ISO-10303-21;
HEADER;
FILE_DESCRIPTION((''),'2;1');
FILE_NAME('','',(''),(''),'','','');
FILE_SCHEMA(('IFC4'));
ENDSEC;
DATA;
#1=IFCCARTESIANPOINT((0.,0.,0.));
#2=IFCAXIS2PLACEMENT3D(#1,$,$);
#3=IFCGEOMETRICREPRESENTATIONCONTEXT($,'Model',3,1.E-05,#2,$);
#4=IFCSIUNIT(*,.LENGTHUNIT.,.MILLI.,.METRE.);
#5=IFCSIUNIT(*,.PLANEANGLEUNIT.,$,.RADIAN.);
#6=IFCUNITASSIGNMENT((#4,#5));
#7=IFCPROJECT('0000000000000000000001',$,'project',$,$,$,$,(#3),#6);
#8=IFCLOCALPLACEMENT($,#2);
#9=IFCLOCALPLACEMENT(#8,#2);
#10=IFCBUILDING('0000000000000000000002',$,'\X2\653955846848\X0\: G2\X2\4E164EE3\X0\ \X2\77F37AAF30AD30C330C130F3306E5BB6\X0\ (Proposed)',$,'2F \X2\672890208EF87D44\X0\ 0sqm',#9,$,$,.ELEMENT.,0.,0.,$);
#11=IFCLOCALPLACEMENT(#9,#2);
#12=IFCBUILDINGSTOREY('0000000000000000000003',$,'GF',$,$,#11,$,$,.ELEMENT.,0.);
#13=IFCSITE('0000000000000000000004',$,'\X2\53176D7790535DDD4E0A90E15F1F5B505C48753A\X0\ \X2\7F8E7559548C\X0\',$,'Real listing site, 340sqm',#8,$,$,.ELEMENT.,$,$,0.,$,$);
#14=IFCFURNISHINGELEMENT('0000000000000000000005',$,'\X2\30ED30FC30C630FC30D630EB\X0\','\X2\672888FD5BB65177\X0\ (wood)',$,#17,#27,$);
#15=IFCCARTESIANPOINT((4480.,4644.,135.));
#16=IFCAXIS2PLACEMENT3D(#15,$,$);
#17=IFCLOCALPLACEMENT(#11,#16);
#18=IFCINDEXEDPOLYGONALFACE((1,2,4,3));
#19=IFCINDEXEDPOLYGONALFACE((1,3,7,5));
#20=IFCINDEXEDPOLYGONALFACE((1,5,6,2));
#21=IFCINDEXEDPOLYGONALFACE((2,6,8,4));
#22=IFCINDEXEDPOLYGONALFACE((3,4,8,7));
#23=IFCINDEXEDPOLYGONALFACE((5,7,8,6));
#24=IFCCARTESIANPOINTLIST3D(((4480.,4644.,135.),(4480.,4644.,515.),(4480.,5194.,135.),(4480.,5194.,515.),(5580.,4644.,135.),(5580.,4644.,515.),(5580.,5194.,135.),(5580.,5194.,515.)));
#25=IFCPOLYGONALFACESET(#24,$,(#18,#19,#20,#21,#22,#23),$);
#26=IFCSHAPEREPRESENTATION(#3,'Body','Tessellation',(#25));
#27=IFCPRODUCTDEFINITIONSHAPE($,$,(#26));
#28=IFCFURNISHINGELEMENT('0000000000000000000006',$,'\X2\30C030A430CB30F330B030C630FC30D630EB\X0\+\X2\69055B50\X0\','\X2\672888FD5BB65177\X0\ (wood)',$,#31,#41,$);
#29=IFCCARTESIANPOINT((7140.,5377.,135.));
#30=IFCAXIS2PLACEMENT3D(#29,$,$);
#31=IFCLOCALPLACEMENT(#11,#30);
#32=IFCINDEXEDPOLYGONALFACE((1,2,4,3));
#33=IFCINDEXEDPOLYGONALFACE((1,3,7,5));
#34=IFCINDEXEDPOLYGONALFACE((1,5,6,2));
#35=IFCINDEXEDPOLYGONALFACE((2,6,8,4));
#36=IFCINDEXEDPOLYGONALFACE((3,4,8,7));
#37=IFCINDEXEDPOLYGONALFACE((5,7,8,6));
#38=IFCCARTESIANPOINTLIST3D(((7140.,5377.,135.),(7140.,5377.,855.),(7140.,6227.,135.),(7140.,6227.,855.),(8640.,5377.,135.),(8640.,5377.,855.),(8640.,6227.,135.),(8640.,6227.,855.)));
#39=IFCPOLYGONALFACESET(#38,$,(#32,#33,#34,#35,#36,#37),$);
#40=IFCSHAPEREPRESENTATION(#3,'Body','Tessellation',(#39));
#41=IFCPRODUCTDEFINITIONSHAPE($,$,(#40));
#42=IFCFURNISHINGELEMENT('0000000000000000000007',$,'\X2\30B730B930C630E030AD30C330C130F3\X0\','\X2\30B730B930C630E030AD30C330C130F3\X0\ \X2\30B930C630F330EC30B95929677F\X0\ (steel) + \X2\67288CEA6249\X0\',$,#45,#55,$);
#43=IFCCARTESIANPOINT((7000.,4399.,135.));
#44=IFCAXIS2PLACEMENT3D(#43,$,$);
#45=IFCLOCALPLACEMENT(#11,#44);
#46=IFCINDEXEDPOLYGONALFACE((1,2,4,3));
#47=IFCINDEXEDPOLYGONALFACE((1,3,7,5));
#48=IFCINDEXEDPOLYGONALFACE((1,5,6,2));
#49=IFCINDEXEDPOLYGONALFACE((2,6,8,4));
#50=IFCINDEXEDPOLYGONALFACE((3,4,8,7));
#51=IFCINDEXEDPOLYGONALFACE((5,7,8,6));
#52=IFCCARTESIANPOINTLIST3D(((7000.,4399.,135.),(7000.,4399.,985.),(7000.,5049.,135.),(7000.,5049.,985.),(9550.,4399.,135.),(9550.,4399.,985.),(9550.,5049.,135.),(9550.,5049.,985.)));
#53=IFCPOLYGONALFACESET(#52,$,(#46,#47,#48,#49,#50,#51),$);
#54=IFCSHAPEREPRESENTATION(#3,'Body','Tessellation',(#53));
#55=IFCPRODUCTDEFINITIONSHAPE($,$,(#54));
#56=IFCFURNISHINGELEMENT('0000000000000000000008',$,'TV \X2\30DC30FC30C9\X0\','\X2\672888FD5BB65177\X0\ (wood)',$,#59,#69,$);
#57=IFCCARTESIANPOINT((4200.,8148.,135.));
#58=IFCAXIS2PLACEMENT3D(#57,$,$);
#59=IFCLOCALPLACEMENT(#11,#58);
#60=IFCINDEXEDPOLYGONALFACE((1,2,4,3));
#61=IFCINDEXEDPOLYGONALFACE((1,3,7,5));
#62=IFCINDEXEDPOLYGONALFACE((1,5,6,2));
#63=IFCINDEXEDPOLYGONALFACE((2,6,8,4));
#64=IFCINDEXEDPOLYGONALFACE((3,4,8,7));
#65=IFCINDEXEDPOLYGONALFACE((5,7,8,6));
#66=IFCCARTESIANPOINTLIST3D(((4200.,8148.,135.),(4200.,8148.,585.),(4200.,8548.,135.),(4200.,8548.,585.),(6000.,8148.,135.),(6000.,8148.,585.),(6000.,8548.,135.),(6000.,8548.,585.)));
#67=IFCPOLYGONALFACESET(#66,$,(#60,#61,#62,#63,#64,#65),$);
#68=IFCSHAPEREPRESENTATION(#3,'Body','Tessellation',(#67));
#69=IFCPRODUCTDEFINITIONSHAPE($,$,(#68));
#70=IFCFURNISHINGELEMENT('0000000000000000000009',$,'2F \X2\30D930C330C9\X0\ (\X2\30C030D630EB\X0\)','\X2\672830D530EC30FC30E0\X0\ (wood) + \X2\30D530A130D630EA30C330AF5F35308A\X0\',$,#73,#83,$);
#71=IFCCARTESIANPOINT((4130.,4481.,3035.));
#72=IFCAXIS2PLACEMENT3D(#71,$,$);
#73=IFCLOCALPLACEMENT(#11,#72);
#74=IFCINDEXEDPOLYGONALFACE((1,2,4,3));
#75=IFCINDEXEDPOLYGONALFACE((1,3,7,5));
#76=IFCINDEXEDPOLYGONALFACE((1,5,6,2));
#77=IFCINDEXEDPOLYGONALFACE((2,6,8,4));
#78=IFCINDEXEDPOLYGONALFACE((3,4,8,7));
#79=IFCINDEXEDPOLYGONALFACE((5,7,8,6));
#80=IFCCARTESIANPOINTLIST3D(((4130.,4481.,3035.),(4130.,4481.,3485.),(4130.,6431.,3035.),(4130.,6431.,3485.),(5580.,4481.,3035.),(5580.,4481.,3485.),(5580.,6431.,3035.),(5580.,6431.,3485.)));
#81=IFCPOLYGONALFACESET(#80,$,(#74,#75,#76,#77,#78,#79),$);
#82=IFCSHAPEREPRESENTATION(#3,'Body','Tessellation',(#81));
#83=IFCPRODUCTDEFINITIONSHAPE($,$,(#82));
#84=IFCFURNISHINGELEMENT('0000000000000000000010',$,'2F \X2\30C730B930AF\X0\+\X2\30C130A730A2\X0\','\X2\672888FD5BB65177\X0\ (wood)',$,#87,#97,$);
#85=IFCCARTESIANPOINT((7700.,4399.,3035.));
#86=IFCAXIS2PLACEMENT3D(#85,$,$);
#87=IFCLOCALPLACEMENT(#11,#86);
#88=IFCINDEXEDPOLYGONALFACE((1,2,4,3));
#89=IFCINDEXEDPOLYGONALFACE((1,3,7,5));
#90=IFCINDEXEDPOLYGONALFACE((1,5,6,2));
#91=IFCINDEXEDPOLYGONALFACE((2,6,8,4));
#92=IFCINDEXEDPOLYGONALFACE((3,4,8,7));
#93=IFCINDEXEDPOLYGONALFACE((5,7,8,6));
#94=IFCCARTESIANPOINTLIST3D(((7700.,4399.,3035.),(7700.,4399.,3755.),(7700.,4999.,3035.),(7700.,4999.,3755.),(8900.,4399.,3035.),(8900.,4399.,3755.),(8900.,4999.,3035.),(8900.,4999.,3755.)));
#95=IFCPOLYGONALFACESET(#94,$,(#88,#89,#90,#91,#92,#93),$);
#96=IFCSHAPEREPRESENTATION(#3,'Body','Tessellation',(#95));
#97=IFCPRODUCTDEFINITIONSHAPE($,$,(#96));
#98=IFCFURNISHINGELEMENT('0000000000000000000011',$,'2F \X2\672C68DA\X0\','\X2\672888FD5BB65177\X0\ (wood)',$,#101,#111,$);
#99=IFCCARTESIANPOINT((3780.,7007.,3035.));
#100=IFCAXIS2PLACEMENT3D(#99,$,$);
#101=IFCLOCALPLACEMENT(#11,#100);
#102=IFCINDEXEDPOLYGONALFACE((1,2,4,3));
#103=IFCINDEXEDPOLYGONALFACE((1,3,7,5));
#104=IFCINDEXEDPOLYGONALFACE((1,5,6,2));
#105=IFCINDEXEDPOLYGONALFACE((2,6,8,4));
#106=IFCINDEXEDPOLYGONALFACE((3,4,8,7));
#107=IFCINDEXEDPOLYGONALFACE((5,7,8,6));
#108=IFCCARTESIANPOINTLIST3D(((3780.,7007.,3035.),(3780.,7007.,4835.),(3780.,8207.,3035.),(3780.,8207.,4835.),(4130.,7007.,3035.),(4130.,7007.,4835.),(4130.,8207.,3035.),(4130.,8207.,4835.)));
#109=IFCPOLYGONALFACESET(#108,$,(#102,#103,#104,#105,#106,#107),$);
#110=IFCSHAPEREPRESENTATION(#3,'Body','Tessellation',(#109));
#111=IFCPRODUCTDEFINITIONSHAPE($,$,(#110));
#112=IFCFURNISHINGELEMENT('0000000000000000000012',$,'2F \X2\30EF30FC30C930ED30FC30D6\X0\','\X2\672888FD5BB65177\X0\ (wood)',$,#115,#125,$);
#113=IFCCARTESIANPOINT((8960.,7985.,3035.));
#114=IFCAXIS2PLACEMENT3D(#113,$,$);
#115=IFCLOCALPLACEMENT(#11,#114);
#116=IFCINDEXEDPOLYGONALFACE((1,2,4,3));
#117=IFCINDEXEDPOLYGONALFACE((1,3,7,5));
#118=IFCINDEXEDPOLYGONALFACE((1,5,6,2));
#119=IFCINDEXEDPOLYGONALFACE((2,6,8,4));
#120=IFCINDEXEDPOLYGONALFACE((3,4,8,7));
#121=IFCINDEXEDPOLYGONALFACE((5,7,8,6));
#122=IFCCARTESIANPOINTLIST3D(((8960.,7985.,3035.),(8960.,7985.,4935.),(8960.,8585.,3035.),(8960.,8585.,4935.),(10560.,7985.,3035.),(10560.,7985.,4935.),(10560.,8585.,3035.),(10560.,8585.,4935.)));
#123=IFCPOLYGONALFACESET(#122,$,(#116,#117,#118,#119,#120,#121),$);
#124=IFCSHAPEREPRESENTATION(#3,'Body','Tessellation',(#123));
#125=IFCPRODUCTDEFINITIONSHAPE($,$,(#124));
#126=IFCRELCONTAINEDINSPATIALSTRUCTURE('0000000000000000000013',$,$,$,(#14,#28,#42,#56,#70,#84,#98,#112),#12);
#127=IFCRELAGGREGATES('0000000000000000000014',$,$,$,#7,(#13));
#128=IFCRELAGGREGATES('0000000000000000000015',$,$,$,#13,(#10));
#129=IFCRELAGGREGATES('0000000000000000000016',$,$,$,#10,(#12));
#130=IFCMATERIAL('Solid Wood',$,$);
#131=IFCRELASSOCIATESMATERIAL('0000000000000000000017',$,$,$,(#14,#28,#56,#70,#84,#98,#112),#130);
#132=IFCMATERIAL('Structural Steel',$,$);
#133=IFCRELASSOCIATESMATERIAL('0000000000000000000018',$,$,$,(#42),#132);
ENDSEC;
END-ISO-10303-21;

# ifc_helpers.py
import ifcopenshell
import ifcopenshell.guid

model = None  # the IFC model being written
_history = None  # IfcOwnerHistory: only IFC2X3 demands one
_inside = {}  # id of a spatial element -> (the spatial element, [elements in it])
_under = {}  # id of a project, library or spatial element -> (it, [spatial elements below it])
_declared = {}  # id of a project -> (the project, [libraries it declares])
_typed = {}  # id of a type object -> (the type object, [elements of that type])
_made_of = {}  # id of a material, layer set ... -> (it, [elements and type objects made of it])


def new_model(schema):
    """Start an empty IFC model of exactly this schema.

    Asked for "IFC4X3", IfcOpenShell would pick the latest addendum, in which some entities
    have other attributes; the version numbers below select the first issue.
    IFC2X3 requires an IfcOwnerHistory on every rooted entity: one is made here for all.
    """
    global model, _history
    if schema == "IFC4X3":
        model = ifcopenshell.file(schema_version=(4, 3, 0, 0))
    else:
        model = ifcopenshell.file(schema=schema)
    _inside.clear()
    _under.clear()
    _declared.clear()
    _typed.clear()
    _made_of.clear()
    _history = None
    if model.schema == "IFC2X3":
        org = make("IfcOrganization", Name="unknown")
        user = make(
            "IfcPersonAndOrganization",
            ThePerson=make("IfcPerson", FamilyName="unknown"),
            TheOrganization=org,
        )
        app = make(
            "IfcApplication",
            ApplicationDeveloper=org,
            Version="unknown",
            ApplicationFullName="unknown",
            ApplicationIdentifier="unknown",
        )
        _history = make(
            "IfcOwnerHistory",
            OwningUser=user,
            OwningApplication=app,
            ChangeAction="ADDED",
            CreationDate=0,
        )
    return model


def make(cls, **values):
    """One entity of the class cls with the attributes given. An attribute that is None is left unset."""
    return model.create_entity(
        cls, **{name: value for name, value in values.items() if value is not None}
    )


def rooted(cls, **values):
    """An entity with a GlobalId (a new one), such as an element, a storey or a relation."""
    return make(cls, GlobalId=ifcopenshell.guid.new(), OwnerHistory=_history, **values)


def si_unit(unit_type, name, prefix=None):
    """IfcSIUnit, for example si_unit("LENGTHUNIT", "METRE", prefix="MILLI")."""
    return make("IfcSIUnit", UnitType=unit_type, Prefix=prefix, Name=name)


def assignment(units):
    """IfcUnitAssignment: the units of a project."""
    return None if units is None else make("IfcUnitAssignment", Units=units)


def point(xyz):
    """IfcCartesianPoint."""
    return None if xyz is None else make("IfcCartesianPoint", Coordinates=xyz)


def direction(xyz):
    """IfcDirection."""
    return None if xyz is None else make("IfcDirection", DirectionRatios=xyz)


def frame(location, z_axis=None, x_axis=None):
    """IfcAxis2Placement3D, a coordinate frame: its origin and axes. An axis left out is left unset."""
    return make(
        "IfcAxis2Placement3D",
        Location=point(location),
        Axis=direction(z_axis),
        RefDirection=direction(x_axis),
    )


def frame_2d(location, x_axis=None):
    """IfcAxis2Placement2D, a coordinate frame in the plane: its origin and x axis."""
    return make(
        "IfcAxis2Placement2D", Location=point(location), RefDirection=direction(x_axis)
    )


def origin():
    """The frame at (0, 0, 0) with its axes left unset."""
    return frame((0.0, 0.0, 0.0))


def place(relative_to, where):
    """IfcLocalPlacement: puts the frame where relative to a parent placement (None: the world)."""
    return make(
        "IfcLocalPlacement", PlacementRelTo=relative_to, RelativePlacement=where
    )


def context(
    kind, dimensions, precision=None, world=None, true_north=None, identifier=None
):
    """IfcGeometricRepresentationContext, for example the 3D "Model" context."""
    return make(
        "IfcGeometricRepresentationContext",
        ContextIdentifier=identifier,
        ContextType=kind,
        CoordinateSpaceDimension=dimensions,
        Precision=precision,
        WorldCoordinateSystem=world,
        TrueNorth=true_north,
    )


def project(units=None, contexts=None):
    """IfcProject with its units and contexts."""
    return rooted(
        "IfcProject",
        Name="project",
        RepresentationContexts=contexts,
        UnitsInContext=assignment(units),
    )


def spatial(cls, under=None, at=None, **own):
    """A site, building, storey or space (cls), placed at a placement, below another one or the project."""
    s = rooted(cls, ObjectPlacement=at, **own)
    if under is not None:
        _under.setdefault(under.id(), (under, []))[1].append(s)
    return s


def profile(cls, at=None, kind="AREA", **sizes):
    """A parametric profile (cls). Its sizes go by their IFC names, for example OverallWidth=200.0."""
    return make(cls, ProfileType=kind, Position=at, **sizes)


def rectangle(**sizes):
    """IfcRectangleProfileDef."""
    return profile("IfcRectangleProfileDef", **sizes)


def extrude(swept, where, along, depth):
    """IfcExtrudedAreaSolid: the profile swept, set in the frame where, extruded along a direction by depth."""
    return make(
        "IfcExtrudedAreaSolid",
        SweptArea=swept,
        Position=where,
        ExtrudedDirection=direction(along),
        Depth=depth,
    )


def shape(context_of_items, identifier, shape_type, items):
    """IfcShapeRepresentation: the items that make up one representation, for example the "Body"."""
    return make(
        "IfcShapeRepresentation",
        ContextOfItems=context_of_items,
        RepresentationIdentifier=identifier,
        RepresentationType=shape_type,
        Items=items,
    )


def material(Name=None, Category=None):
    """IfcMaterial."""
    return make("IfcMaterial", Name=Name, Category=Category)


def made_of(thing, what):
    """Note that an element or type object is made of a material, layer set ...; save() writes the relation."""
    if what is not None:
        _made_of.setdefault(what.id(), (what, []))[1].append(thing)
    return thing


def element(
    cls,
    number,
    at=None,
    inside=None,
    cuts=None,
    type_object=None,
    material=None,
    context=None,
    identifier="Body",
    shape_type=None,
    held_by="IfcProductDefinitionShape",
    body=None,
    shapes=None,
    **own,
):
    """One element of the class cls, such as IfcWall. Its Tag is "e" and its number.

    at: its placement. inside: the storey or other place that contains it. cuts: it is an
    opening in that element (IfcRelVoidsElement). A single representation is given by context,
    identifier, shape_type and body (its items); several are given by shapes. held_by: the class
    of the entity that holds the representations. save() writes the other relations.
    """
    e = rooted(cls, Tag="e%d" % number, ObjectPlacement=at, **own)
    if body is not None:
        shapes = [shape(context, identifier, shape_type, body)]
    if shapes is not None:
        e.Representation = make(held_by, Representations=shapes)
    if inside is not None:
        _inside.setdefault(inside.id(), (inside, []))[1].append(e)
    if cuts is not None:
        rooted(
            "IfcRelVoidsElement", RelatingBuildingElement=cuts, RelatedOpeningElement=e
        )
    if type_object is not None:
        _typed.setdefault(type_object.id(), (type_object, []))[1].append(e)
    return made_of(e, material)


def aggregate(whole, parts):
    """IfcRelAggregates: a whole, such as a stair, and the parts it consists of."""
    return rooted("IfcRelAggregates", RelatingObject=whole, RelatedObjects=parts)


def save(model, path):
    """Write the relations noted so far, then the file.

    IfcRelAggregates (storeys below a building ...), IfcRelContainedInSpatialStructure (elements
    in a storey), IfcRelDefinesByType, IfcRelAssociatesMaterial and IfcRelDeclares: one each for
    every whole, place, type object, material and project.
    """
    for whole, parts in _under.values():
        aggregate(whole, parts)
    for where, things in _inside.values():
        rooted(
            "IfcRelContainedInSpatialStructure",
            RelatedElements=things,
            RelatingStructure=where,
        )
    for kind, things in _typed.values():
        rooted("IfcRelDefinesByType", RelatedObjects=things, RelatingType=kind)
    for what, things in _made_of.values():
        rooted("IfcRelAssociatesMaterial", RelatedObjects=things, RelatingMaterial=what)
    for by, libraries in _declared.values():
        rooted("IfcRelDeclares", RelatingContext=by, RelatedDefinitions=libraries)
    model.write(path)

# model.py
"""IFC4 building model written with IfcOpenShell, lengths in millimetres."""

from ifc_helpers import new_model, si_unit, frame, frame_2d, origin, place, context, project, spatial, rectangle, extrude, material, element, save


model = new_model("IFC4")

# Units and contexts
model_context = context("Model", 3, precision=1e-05, world=origin())
ifc_project = project(units=[si_unit("LENGTHUNIT", "METRE", prefix="MILLI"), si_unit("PLANEANGLEUNIT", "RADIAN")], contexts=[model_context])

# Site, building, storey
site_placement = place(None, origin())
site = spatial("IfcSite", under=ifc_project, at=site_placement, Name="北海道川上郡弟子屈町 美留和", ObjectType="Real listing site, 340sqm", CompositionType="ELEMENT", RefElevation=0.0)
building_placement = place(site_placement, origin())
building = spatial("IfcBuilding", under=site, at=building_placement, Name="改善案: G2世代 石窯キッチンの家 (Proposed)", ObjectType="2F 木造軸組 0sqm", CompositionType="ELEMENT", ElevationOfRefHeight=0.0, ElevationOfTerrain=0.0)
storey_placement = place(building_placement, origin())
storey = spatial("IfcBuildingStorey", under=building, at=storey_placement, Name="GF", CompositionType="ELEMENT", Elevation=0.0)

# Shared definitions
ifc_material_1 = material(Name="Solid Wood")

# Shared definitions
ifc_material_2 = material(Name="Structural Steel")

# Furnishing elements
furnishing_1_placement = place(storey_placement, frame((4480.0, 4644.0, 135.0)))
element("IfcFurnishingElement", 1, at=furnishing_1_placement, inside=storey, material=ifc_material_1, Name="ローテーブル", Description="木製家具 (wood)", context=model_context, shape_type="SweptSolid", body=[
    extrude(rectangle(XDim=1100.0, YDim=550.0, at=frame_2d((550.0, 275.0))), frame((4480.0, 4644.0, 135.0)), (0.0, 0.0, 1.0), 380.0),
])
furnishing_2_placement = place(storey_placement, frame((7140.0, 5377.0, 135.0)))
element("IfcFurnishingElement", 2, at=furnishing_2_placement, inside=storey, material=ifc_material_1, Name="ダイニングテーブル+椅子", Description="木製家具 (wood)", context=model_context, shape_type="SweptSolid", body=[
    extrude(rectangle(XDim=1500.0, YDim=850.0, at=frame_2d((750.0, 425.0))), frame((7140.0, 5377.0, 135.0)), (0.0, 0.0, 1.0), 720.0),
])
furnishing_3_placement = place(storey_placement, frame((7000.0, 4399.0, 135.0)))
element("IfcFurnishingElement", 3, at=furnishing_3_placement, inside=storey, material=ifc_material_2, Name="システムキッチン", Description="システムキッチン ステンレス天板 (steel) + 木質扉", context=model_context, shape_type="SweptSolid", body=[
    extrude(rectangle(XDim=2550.0, YDim=650.0, at=frame_2d((1275.0, 325.0))), frame((7000.0, 4399.0, 135.0)), (0.0, 0.0, 1.0), 850.0),
])
furnishing_4_placement = place(storey_placement, frame((4200.0, 8148.0, 135.0)))
element("IfcFurnishingElement", 4, at=furnishing_4_placement, inside=storey, material=ifc_material_1, Name="TV ボード", Description="木製家具 (wood)", context=model_context, shape_type="SweptSolid", body=[
    extrude(rectangle(XDim=1800.0, YDim=400.0, at=frame_2d((900.0, 200.0))), frame((4200.0, 8148.0, 135.0)), (0.0, 0.0, 1.0), 450.0),
])
furnishing_5_placement = place(storey_placement, frame((4130.0, 4481.0, 3035.0)))
element("IfcFurnishingElement", 5, at=furnishing_5_placement, inside=storey, material=ifc_material_1, Name="2F ベッド (ダブル)", Description="木フレーム (wood) + ファブリック張り", context=model_context, shape_type="SweptSolid", body=[
    extrude(rectangle(XDim=1450.0, YDim=1950.0, at=frame_2d((725.0, 975.0))), frame((4130.0, 4481.0, 3035.0)), (0.0, 0.0, 1.0), 450.0),
])
furnishing_6_placement = place(storey_placement, frame((7700.0, 4399.0, 3035.0)))
element("IfcFurnishingElement", 6, at=furnishing_6_placement, inside=storey, material=ifc_material_1, Name="2F デスク+チェア", Description="木製家具 (wood)", context=model_context, shape_type="SweptSolid", body=[
    extrude(rectangle(XDim=1200.0, YDim=600.0, at=frame_2d((600.0, 300.0))), frame((7700.0, 4399.0, 3035.0)), (0.0, 0.0, 1.0), 720.0),
])
furnishing_7_placement = place(storey_placement, frame((3780.0, 7007.0, 3035.0)))
element("IfcFurnishingElement", 7, at=furnishing_7_placement, inside=storey, material=ifc_material_1, Name="2F 本棚", Description="木製家具 (wood)", context=model_context, shape_type="SweptSolid", body=[
    extrude(rectangle(XDim=350.0, YDim=1200.0, at=frame_2d((175.0, 600.0))), frame((3780.0, 7007.0, 3035.0)), (0.0, 0.0, 1.0), 1800.0),
])
furnishing_8_placement = place(storey_placement, frame((8960.0, 7985.0, 3035.0)))
element("IfcFurnishingElement", 8, at=furnishing_8_placement, inside=storey, material=ifc_material_1, Name="2F ワードローブ", Description="木製家具 (wood)", context=model_context, shape_type="SweptSolid", body=[
    extrude(rectangle(XDim=1600.0, YDim=600.0, at=frame_2d((800.0, 300.0))), frame((8960.0, 7985.0, 3035.0)), (0.0, 0.0, 1.0), 1900.0),
])

save(model, "model.ifc")
